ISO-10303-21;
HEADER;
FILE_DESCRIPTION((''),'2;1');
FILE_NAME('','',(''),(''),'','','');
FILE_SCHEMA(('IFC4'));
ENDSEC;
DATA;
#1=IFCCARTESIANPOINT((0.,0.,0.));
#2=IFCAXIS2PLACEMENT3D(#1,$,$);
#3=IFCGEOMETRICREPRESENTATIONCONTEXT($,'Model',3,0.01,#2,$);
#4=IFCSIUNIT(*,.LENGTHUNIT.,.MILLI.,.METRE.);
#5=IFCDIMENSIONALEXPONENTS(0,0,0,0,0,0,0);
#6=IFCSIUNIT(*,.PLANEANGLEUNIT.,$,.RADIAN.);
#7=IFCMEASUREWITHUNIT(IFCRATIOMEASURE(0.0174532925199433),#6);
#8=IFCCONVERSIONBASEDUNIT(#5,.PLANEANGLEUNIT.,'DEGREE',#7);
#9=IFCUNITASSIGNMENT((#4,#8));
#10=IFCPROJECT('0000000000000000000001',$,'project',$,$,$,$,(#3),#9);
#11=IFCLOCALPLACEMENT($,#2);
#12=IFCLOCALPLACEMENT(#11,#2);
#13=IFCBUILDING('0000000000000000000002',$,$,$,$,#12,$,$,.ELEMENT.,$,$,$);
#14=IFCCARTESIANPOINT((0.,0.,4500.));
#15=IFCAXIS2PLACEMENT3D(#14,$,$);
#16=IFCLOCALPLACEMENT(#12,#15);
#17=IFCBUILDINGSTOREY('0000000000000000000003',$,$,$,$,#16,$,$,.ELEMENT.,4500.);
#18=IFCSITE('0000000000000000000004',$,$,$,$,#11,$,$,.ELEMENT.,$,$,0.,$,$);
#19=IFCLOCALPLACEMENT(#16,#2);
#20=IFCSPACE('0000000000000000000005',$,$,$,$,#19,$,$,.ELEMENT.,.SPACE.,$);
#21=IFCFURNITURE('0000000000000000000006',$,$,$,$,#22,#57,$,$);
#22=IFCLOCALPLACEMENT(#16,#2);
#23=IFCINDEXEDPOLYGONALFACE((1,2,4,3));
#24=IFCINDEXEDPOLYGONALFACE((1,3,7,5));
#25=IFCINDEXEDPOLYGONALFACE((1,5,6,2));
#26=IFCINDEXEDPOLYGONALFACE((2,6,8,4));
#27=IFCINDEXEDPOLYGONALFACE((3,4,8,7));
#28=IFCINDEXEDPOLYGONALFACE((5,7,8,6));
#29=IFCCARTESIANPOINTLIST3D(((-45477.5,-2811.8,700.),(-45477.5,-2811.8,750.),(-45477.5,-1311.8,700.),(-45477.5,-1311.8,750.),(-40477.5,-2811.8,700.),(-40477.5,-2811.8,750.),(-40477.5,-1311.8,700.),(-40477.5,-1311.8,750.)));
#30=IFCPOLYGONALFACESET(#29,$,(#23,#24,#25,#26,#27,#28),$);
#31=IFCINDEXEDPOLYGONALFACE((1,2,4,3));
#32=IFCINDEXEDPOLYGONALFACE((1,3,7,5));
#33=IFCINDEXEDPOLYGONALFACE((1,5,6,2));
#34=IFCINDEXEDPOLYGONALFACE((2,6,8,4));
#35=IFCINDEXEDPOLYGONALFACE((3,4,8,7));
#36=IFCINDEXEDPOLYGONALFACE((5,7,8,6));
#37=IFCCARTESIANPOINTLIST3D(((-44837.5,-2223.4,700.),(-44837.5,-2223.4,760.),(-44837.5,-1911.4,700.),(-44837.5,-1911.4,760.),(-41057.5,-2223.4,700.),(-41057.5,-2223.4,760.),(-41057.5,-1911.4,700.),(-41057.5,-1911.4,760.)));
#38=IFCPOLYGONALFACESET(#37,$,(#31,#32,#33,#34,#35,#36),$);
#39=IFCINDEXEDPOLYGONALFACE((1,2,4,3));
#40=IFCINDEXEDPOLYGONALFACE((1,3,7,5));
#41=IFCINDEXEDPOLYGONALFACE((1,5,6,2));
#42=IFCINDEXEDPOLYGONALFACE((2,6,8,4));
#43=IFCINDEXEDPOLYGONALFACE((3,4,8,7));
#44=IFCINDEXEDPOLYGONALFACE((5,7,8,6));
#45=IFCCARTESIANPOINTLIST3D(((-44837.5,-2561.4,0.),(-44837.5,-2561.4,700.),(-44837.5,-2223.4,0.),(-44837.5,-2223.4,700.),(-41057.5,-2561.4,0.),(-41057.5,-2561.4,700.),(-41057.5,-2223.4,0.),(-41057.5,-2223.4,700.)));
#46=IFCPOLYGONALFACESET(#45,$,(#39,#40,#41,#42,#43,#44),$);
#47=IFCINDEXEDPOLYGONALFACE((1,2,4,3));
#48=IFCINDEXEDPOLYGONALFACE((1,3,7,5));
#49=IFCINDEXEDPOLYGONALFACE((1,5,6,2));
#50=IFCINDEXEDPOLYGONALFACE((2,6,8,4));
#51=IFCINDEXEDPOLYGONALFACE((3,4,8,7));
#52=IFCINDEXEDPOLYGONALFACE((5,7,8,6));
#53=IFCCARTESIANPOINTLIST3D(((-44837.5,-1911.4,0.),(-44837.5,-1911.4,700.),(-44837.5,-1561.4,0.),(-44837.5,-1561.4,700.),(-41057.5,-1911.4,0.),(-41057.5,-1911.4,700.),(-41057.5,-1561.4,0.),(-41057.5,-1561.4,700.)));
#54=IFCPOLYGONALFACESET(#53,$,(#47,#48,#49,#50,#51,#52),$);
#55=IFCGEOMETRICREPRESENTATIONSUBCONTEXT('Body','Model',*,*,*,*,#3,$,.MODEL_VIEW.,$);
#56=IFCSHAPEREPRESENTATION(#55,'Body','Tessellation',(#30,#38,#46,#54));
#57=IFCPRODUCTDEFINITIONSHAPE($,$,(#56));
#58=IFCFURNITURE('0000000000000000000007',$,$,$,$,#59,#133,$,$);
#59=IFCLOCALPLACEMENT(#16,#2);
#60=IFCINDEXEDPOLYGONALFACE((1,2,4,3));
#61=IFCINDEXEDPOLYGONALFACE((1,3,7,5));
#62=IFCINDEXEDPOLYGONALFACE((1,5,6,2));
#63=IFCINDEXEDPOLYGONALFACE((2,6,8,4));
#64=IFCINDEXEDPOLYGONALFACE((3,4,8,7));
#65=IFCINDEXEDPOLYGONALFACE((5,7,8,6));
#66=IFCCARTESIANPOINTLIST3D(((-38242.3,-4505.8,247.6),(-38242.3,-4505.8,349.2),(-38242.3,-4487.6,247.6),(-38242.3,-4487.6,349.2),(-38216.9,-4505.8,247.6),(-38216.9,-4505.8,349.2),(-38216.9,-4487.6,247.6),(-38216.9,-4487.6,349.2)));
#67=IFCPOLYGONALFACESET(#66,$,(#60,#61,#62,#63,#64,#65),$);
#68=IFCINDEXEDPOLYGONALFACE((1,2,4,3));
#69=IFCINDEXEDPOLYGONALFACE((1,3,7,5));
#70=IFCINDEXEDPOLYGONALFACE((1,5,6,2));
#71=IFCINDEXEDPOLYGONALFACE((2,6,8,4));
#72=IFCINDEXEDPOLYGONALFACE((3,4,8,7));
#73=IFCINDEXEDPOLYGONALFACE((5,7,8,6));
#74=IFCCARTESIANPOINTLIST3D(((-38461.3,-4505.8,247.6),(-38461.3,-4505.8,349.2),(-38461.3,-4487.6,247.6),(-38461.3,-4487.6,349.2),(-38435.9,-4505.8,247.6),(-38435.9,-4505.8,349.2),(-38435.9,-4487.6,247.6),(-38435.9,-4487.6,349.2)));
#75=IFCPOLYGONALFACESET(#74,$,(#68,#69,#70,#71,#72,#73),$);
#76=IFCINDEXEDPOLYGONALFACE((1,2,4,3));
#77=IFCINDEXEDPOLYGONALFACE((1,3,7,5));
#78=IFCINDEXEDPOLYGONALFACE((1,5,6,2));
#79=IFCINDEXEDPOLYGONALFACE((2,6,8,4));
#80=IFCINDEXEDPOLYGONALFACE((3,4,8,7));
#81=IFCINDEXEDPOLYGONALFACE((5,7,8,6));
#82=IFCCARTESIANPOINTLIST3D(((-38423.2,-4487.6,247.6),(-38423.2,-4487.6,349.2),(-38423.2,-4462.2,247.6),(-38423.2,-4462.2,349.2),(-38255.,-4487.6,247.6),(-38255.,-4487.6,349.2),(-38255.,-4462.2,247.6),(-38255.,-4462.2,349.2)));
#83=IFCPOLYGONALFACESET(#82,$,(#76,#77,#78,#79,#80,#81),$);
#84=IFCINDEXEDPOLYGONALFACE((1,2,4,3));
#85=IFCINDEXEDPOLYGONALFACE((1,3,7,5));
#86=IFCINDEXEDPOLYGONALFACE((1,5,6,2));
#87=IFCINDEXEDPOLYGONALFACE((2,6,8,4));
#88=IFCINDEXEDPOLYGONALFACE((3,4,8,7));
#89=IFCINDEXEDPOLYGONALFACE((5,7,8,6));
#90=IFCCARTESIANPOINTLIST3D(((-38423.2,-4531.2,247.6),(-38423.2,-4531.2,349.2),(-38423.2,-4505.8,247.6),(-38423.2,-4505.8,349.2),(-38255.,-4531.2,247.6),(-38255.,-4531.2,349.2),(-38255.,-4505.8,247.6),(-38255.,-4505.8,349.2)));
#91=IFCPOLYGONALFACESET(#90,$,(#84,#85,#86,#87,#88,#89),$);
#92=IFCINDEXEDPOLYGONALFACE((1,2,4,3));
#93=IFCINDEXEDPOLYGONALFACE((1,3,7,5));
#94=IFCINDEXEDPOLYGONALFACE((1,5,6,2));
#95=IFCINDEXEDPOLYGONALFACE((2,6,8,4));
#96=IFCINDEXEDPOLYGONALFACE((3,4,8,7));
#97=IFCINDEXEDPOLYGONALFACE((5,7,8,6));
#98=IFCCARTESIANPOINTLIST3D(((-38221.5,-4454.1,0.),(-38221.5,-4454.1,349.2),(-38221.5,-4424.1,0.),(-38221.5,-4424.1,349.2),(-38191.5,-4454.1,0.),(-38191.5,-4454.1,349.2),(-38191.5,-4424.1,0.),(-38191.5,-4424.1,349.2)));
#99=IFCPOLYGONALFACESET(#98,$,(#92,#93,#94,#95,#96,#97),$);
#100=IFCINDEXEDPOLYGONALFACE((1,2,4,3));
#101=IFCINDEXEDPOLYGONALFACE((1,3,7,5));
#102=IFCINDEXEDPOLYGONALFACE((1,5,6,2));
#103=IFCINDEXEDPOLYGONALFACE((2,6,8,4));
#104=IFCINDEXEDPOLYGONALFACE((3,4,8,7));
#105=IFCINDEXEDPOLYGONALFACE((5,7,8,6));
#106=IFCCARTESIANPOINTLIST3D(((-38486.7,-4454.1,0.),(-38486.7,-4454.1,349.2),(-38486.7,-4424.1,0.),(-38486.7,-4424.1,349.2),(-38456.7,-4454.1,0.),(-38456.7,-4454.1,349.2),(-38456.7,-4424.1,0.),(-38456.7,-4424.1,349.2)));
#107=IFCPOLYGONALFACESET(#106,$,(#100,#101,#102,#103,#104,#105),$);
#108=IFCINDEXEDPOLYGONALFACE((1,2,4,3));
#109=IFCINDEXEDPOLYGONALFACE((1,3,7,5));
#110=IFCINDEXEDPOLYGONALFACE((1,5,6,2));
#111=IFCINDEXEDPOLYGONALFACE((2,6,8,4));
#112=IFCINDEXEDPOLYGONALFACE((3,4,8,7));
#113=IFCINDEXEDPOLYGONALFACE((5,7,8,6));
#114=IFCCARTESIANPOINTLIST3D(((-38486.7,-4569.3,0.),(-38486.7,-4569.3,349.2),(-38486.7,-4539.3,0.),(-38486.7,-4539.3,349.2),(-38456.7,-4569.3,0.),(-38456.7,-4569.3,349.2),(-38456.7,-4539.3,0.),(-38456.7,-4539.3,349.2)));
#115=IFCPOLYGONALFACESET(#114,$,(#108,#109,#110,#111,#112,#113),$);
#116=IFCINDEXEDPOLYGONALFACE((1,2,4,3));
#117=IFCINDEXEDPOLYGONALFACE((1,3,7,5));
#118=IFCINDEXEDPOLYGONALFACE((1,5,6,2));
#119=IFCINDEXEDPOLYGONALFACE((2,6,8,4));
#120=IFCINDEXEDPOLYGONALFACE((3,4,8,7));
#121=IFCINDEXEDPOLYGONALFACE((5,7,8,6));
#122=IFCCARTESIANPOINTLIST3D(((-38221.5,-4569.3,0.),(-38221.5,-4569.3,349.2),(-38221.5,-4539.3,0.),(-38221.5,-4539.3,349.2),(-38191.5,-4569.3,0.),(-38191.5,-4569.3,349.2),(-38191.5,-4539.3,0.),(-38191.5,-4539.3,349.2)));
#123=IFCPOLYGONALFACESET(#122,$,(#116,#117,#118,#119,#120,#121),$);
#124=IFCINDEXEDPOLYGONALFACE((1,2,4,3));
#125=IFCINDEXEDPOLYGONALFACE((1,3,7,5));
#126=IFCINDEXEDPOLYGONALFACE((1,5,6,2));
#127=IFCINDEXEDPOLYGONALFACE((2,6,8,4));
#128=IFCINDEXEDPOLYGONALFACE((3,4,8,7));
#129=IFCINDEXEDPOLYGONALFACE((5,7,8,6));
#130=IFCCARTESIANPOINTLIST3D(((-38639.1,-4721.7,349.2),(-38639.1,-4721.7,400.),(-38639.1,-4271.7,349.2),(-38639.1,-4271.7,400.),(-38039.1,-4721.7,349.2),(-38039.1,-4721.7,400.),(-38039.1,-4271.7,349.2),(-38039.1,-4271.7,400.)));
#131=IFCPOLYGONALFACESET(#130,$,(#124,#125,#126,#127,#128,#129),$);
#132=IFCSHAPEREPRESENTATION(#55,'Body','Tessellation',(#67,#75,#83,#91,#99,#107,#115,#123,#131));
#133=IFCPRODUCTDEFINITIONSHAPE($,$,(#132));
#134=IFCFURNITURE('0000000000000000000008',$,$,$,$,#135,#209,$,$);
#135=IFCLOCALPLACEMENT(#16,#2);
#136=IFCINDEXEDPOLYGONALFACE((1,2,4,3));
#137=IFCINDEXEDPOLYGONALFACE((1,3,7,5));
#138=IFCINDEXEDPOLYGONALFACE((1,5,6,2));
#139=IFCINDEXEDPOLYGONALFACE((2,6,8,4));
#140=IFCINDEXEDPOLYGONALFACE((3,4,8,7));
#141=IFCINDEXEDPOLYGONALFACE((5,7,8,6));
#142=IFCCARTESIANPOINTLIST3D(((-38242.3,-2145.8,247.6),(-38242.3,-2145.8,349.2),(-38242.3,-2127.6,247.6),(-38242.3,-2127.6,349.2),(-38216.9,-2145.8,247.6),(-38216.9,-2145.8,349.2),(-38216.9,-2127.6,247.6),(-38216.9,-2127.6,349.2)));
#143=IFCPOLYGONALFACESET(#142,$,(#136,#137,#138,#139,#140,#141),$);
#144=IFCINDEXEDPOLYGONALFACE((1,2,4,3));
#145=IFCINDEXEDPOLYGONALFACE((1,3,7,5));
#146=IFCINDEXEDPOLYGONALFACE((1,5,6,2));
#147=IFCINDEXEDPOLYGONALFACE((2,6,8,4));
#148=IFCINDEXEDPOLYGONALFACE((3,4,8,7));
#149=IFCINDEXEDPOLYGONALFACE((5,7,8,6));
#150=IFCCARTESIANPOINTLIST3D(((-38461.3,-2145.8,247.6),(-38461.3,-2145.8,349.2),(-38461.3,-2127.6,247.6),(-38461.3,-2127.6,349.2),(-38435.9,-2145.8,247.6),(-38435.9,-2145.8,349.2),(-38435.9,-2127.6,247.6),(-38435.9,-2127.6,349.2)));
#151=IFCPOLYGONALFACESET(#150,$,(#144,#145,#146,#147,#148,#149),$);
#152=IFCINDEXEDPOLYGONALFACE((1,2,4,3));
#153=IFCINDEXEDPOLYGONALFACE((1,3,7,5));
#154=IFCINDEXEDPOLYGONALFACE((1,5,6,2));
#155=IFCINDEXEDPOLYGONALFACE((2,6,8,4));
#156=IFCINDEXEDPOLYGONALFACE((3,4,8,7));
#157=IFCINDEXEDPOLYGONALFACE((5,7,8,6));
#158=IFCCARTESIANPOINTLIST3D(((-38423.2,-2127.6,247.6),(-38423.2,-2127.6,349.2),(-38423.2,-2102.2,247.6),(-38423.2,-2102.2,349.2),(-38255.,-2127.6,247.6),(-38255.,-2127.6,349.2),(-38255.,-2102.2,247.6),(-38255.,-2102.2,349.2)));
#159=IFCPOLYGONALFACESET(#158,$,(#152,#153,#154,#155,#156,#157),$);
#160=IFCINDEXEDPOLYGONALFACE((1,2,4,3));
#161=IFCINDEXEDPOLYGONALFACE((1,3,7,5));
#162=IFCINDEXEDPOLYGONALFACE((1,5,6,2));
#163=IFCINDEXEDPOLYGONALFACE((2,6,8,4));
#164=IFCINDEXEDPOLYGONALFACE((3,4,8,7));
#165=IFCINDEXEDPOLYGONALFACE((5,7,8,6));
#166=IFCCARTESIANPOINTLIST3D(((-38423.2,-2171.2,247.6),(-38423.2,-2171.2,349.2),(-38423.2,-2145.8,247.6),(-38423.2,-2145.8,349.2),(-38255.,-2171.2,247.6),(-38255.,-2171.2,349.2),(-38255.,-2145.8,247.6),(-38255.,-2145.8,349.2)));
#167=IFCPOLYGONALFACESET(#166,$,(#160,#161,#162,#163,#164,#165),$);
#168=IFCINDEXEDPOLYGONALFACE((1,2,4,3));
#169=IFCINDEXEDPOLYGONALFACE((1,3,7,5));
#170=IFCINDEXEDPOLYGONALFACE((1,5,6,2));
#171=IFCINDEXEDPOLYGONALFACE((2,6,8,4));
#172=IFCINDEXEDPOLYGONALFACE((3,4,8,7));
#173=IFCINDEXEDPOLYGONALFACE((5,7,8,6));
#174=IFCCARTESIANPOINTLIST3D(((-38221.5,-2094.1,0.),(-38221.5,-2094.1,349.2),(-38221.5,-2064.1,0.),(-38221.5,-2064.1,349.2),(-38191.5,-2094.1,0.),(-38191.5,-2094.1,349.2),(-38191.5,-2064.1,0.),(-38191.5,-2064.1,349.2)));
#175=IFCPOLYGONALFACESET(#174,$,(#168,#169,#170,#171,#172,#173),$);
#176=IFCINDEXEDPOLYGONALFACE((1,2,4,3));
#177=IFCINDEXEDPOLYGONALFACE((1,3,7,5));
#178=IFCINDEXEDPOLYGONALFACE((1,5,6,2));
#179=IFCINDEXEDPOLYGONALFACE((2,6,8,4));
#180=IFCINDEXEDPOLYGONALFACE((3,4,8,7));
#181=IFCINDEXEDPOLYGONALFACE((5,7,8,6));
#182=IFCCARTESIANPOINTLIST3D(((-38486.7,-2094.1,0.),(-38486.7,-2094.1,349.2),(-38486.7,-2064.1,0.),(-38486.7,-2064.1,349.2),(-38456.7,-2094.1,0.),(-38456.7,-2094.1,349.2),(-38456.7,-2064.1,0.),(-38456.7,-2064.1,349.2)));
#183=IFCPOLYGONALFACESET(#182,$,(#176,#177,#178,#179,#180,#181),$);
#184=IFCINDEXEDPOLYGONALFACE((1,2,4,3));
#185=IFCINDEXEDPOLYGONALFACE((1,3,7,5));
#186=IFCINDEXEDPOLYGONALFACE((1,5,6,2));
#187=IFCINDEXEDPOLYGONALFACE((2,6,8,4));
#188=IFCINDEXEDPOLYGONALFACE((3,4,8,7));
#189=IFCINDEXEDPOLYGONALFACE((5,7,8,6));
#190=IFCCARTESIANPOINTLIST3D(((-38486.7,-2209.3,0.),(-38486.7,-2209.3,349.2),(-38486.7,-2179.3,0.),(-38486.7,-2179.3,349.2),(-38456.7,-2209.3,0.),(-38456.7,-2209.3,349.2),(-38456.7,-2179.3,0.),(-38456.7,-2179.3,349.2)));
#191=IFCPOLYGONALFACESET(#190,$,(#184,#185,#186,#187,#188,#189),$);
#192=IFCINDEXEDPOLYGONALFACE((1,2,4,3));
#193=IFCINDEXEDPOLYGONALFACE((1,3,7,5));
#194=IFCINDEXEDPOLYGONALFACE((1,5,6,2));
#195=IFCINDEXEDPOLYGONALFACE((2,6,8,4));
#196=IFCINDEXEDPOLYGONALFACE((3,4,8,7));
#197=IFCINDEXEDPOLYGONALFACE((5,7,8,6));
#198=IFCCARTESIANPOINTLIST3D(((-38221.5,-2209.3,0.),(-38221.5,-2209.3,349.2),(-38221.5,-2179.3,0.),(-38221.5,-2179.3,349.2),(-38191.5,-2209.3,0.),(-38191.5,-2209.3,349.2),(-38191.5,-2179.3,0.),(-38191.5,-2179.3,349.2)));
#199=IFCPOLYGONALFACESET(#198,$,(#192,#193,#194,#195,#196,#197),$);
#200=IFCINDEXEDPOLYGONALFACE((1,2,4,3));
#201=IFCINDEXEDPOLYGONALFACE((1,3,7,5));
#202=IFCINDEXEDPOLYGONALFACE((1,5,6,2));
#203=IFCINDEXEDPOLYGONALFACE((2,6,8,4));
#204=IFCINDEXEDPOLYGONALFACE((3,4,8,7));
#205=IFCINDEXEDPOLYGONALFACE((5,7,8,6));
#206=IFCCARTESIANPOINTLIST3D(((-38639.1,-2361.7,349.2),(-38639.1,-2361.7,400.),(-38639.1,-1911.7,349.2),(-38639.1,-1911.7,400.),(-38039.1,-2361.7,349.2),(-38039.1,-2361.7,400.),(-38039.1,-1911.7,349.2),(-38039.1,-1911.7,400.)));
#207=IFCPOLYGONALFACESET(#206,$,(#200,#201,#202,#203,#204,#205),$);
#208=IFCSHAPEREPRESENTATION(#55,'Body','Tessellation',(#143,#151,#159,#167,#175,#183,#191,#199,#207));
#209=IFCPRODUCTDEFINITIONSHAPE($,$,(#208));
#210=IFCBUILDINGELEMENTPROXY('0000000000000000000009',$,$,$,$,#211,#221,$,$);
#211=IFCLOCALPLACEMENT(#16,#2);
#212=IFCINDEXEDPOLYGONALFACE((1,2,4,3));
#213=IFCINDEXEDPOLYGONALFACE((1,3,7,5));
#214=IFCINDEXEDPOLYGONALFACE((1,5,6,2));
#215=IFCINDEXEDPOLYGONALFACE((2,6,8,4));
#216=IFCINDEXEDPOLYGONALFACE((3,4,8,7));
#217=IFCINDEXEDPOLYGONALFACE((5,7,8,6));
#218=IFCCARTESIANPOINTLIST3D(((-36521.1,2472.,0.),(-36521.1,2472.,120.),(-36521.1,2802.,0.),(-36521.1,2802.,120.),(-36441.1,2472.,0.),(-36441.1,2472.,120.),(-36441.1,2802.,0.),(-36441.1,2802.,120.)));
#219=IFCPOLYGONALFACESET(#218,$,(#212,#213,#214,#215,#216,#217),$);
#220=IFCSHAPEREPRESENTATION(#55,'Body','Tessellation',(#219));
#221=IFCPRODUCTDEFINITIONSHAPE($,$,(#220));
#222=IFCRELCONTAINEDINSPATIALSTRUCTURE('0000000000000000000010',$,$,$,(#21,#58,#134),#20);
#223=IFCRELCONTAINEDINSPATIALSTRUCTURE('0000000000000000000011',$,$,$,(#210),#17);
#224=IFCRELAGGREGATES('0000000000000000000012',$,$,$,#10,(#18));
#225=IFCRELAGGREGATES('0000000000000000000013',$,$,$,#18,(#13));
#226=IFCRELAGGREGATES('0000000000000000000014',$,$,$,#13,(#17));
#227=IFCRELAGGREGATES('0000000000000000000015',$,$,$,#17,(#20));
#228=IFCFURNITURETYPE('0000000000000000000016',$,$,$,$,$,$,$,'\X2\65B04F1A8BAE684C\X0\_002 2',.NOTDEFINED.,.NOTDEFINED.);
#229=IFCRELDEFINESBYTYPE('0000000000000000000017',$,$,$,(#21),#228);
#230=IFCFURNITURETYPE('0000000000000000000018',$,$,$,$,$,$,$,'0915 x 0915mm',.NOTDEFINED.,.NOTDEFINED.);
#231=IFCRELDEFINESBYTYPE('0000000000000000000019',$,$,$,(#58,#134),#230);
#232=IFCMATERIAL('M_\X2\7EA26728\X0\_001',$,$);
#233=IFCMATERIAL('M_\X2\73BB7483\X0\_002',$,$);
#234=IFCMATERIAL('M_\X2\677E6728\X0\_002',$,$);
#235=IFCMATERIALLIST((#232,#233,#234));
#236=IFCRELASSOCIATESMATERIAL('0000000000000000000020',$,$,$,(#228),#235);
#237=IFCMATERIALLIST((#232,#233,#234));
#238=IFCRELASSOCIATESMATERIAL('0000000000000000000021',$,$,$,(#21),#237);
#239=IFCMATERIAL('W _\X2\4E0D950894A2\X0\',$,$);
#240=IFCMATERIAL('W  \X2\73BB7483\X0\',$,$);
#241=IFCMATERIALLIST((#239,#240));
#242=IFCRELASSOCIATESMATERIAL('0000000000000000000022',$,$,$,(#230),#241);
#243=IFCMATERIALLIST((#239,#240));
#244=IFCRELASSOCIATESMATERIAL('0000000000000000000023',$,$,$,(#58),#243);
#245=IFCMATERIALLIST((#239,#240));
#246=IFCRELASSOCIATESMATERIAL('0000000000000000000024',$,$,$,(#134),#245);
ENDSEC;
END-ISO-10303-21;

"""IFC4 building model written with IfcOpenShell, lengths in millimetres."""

from ifc_helpers import new_model, entity, si_unit, converted_unit, frame, frame_2d, origin, origin_2d_with_axis, place, context, subcontext, project, spatial, rectangle, extrude, source, transform, mapped, material, material_list, type_object, type_shapes, element, save


model = new_model("IFC4")

# Units and contexts
model_context = context("Model", 3, precision=0.01, world=origin())
body_context = subcontext(model_context, "Body", "Model", "MODEL_VIEW")
ifc_project = project(units=[si_unit("LENGTHUNIT", "METRE", prefix="MILLI"), converted_unit("PLANEANGLEUNIT", "DEGREE", entity("IfcRatioMeasure", 0.0174532925199433), si_unit("PLANEANGLEUNIT", "RADIAN"), dimensions=[0, 0, 0, 0, 0, 0, 0])], contexts=[model_context])

# Site, building, storey
site_placement = place(None, origin())
site = spatial("IfcSite", under=ifc_project, at=site_placement, CompositionType="ELEMENT", RefElevation=0.0)
building_placement = place(site_placement, origin())
building = spatial("IfcBuilding", under=site, at=building_placement, CompositionType="ELEMENT")
storey_placement = place(building_placement, frame((0.0, 0.0, 4500.0)))
storey = spatial("IfcBuildingStorey", under=building, at=storey_placement, CompositionType="ELEMENT", Elevation=4500.0)

# Shared definitions
space_placement = place(storey_placement, origin())
space = spatial("IfcSpace", under=storey, at=space_placement, CompositionType="ELEMENT", PredefinedType="SPACE")

# Furniture
ifc_material_1 = material(Name="M_红木_001")
ifc_material_2 = material(Name="M_玻璃_002")
ifc_material_3 = material(Name="M_松木_002")
ifc_material_list_1 = material_list([ifc_material_1, ifc_material_2, ifc_material_3])
ifc_material_list_2 = material_list([ifc_material_1, ifc_material_2, ifc_material_3])
furniture_type_1 = type_object("IfcFurnitureType", ElementType="新会议桌_002 2", AssemblyPlace="NOTDEFINED", PredefinedType="NOTDEFINED", material=ifc_material_list_2)
shared_shape_1 = source(origin(), body_context, "Body", "SweptSolid", [
    extrude(rectangle(XDim=5000.0, YDim=1500.0, at=frame_2d((0.0, 0.0), x_axis=(1.0, 0.0))), frame((0.0, 0.0, 700.0), z_axis=(0.0, 0.0, 1.0), x_axis=(-1.0, 0.0, 0.0)), (0.0, 0.0, 1.0), 50.0),
    extrude(rectangle(XDim=3780.0, YDim=312.0, at=origin_2d_with_axis()), frame((30.0, -5.6, 700.0), z_axis=(0.0, 0.0, 1.0), x_axis=(-1.0, 0.0, 0.0)), (0.0, 0.0, 1.0), 60.0),
    extrude(rectangle(XDim=338.0, YDim=3780.0, at=origin_2d_with_axis()), frame((30.0, -330.6, 0.0), z_axis=(0.0, 0.0, 1.0), x_axis=(0.0, 1.0, 0.0)), (0.0, 0.0, 1.0), 700.0),
    extrude(rectangle(XDim=350.0, YDim=3780.0, at=origin_2d_with_axis()), frame((30.0, 325.4, 0.0), z_axis=(0.0, 0.0, 1.0), x_axis=(0.0, -1.0, 0.0)), (0.0, 0.0, 1.0), 700.0),
])
type_shapes(furniture_type_1, [shared_shape_1])
furniture_1_placement = place(space_placement, frame((-42977.5, -2061.8, 0.0)))
element("IfcFurniture", 1, at=furniture_1_placement, inside=space, type_object=furniture_type_1, material=ifc_material_list_1, context=body_context, shape_type="MappedRepresentation", body=[
    mapped(shared_shape_1, transform((0.0, 0.0, 0.0), scale=1.0)),
])
ifc_material_4 = material(Name="W _不锈钢")
ifc_material_5 = material(Name="W  玻璃")
ifc_material_list_3 = material_list([ifc_material_4, ifc_material_5])
ifc_material_list_4 = material_list([ifc_material_4, ifc_material_5])
furniture_type_2 = type_object("IfcFurnitureType", ElementType="0915 x 0915mm", AssemblyPlace="NOTDEFINED", PredefinedType="NOTDEFINED", material=ifc_material_list_4)
shared_shape_2 = source(origin(), body_context, "Body", "SweptSolid", [
    extrude(rectangle(XDim=25.4, YDim=18.2, at=origin_2d_with_axis()), frame((109.5, 0.0, 247.6)), (0.0, 0.0, 1.0), 101.6),
    extrude(rectangle(XDim=18.2, YDim=25.4, at=origin_2d_with_axis()), frame((-109.5, 0.0, 247.6), z_axis=(0.0, 0.0, 1.0), x_axis=(0.0, 1.0, 0.0)), (0.0, 0.0, 1.0), 101.6),
    extrude(rectangle(XDim=168.2, YDim=25.4, at=frame_2d((0.0, 0.0), x_axis=(1.0, 0.0))), frame((0.0, 21.8, 247.6), z_axis=(0.0, 0.0, 1.0), x_axis=(-1.0, 0.0, 0.0)), (0.0, 0.0, 1.0), 101.6),
    extrude(rectangle(XDim=25.4, YDim=168.2, at=origin_2d_with_axis()), frame((0.0, -21.8, 247.6), z_axis=(0.0, 0.0, 1.0), x_axis=(0.0, 1.0, 0.0)), (0.0, 0.0, 1.0), 101.6),
    extrude(rectangle(XDim=30.0, YDim=30.0, at=origin_2d_with_axis()), frame((132.6, 57.6, 0.0), z_axis=(0.0, 0.0, 1.0), x_axis=(0.0, -1.0, 0.0)), (0.0, 0.0, 1.0), 349.2),
    extrude(rectangle(XDim=30.0, YDim=30.0, at=frame_2d((0.0, 0.0), x_axis=(1.0, 0.0))), frame((-132.6, 57.6, 0.0), z_axis=(0.0, 0.0, 1.0), x_axis=(-1.0, 0.0, 0.0)), (0.0, 0.0, 1.0), 349.2),
    extrude(rectangle(XDim=30.0, YDim=30.0, at=frame_2d((0.0, 0.0), x_axis=(1.0, 0.0))), frame((-132.6, -57.6, 0.0), z_axis=(0.0, 0.0, 1.0), x_axis=(0.0, 1.0, 0.0)), (0.0, 0.0, 1.0), 349.2),
    extrude(rectangle(XDim=30.0, YDim=30.0, at=frame_2d((0.0, 0.0), x_axis=(1.0, 0.0))), frame((132.6, -57.6, 0.0)), (0.0, 0.0, 1.0), 349.2),
    extrude(rectangle(XDim=600.0, YDim=450.0, at=origin_2d_with_axis()), frame((0.0, 0.0, 349.2), z_axis=(0.0, 0.0, 1.0), x_axis=(-1.0, 0.0, 0.0)), (0.0, 0.0, 1.0), 50.8),
])
type_shapes(furniture_type_2, [shared_shape_2])
furniture_2_placement = place(space_placement, frame((-38339.1, -4496.7, 0.0)))
element("IfcFurniture", 2, at=furniture_2_placement, inside=space, type_object=furniture_type_2, material=ifc_material_list_3, context=body_context, shape_type="MappedRepresentation", body=[
    mapped(shared_shape_2, transform((0.0, 0.0, 0.0), scale=1.0)),
])
ifc_material_list_5 = material_list([ifc_material_4, ifc_material_5])
furniture_3_placement = place(space_placement, frame((-38339.1, -2136.7, 0.0)))
element("IfcFurniture", 3, at=furniture_3_placement, inside=space, type_object=furniture_type_2, material=ifc_material_list_5, context=body_context, shape_type="MappedRepresentation", body=[
    mapped(shared_shape_2, transform((0.0, 0.0, 0.0), scale=1.0)),
])

# Building element proxy
proxy_placement = place(storey_placement, frame((-36521.1, 2472.0, 0.0)))
element("IfcBuildingElementProxy", 4, at=proxy_placement, inside=storey, context=body_context, shape_type="SweptSolid", body=[
    extrude(rectangle(XDim=330.0, YDim=80.0, at=origin_2d_with_axis()), frame((40.0, 165.0, 0.0), z_axis=(0.0, 0.0, 1.0), x_axis=(0.0, -1.0, 0.0)), (0.0, 0.0, 1.0), 120.0),
])

save(model, "model.ifc")
